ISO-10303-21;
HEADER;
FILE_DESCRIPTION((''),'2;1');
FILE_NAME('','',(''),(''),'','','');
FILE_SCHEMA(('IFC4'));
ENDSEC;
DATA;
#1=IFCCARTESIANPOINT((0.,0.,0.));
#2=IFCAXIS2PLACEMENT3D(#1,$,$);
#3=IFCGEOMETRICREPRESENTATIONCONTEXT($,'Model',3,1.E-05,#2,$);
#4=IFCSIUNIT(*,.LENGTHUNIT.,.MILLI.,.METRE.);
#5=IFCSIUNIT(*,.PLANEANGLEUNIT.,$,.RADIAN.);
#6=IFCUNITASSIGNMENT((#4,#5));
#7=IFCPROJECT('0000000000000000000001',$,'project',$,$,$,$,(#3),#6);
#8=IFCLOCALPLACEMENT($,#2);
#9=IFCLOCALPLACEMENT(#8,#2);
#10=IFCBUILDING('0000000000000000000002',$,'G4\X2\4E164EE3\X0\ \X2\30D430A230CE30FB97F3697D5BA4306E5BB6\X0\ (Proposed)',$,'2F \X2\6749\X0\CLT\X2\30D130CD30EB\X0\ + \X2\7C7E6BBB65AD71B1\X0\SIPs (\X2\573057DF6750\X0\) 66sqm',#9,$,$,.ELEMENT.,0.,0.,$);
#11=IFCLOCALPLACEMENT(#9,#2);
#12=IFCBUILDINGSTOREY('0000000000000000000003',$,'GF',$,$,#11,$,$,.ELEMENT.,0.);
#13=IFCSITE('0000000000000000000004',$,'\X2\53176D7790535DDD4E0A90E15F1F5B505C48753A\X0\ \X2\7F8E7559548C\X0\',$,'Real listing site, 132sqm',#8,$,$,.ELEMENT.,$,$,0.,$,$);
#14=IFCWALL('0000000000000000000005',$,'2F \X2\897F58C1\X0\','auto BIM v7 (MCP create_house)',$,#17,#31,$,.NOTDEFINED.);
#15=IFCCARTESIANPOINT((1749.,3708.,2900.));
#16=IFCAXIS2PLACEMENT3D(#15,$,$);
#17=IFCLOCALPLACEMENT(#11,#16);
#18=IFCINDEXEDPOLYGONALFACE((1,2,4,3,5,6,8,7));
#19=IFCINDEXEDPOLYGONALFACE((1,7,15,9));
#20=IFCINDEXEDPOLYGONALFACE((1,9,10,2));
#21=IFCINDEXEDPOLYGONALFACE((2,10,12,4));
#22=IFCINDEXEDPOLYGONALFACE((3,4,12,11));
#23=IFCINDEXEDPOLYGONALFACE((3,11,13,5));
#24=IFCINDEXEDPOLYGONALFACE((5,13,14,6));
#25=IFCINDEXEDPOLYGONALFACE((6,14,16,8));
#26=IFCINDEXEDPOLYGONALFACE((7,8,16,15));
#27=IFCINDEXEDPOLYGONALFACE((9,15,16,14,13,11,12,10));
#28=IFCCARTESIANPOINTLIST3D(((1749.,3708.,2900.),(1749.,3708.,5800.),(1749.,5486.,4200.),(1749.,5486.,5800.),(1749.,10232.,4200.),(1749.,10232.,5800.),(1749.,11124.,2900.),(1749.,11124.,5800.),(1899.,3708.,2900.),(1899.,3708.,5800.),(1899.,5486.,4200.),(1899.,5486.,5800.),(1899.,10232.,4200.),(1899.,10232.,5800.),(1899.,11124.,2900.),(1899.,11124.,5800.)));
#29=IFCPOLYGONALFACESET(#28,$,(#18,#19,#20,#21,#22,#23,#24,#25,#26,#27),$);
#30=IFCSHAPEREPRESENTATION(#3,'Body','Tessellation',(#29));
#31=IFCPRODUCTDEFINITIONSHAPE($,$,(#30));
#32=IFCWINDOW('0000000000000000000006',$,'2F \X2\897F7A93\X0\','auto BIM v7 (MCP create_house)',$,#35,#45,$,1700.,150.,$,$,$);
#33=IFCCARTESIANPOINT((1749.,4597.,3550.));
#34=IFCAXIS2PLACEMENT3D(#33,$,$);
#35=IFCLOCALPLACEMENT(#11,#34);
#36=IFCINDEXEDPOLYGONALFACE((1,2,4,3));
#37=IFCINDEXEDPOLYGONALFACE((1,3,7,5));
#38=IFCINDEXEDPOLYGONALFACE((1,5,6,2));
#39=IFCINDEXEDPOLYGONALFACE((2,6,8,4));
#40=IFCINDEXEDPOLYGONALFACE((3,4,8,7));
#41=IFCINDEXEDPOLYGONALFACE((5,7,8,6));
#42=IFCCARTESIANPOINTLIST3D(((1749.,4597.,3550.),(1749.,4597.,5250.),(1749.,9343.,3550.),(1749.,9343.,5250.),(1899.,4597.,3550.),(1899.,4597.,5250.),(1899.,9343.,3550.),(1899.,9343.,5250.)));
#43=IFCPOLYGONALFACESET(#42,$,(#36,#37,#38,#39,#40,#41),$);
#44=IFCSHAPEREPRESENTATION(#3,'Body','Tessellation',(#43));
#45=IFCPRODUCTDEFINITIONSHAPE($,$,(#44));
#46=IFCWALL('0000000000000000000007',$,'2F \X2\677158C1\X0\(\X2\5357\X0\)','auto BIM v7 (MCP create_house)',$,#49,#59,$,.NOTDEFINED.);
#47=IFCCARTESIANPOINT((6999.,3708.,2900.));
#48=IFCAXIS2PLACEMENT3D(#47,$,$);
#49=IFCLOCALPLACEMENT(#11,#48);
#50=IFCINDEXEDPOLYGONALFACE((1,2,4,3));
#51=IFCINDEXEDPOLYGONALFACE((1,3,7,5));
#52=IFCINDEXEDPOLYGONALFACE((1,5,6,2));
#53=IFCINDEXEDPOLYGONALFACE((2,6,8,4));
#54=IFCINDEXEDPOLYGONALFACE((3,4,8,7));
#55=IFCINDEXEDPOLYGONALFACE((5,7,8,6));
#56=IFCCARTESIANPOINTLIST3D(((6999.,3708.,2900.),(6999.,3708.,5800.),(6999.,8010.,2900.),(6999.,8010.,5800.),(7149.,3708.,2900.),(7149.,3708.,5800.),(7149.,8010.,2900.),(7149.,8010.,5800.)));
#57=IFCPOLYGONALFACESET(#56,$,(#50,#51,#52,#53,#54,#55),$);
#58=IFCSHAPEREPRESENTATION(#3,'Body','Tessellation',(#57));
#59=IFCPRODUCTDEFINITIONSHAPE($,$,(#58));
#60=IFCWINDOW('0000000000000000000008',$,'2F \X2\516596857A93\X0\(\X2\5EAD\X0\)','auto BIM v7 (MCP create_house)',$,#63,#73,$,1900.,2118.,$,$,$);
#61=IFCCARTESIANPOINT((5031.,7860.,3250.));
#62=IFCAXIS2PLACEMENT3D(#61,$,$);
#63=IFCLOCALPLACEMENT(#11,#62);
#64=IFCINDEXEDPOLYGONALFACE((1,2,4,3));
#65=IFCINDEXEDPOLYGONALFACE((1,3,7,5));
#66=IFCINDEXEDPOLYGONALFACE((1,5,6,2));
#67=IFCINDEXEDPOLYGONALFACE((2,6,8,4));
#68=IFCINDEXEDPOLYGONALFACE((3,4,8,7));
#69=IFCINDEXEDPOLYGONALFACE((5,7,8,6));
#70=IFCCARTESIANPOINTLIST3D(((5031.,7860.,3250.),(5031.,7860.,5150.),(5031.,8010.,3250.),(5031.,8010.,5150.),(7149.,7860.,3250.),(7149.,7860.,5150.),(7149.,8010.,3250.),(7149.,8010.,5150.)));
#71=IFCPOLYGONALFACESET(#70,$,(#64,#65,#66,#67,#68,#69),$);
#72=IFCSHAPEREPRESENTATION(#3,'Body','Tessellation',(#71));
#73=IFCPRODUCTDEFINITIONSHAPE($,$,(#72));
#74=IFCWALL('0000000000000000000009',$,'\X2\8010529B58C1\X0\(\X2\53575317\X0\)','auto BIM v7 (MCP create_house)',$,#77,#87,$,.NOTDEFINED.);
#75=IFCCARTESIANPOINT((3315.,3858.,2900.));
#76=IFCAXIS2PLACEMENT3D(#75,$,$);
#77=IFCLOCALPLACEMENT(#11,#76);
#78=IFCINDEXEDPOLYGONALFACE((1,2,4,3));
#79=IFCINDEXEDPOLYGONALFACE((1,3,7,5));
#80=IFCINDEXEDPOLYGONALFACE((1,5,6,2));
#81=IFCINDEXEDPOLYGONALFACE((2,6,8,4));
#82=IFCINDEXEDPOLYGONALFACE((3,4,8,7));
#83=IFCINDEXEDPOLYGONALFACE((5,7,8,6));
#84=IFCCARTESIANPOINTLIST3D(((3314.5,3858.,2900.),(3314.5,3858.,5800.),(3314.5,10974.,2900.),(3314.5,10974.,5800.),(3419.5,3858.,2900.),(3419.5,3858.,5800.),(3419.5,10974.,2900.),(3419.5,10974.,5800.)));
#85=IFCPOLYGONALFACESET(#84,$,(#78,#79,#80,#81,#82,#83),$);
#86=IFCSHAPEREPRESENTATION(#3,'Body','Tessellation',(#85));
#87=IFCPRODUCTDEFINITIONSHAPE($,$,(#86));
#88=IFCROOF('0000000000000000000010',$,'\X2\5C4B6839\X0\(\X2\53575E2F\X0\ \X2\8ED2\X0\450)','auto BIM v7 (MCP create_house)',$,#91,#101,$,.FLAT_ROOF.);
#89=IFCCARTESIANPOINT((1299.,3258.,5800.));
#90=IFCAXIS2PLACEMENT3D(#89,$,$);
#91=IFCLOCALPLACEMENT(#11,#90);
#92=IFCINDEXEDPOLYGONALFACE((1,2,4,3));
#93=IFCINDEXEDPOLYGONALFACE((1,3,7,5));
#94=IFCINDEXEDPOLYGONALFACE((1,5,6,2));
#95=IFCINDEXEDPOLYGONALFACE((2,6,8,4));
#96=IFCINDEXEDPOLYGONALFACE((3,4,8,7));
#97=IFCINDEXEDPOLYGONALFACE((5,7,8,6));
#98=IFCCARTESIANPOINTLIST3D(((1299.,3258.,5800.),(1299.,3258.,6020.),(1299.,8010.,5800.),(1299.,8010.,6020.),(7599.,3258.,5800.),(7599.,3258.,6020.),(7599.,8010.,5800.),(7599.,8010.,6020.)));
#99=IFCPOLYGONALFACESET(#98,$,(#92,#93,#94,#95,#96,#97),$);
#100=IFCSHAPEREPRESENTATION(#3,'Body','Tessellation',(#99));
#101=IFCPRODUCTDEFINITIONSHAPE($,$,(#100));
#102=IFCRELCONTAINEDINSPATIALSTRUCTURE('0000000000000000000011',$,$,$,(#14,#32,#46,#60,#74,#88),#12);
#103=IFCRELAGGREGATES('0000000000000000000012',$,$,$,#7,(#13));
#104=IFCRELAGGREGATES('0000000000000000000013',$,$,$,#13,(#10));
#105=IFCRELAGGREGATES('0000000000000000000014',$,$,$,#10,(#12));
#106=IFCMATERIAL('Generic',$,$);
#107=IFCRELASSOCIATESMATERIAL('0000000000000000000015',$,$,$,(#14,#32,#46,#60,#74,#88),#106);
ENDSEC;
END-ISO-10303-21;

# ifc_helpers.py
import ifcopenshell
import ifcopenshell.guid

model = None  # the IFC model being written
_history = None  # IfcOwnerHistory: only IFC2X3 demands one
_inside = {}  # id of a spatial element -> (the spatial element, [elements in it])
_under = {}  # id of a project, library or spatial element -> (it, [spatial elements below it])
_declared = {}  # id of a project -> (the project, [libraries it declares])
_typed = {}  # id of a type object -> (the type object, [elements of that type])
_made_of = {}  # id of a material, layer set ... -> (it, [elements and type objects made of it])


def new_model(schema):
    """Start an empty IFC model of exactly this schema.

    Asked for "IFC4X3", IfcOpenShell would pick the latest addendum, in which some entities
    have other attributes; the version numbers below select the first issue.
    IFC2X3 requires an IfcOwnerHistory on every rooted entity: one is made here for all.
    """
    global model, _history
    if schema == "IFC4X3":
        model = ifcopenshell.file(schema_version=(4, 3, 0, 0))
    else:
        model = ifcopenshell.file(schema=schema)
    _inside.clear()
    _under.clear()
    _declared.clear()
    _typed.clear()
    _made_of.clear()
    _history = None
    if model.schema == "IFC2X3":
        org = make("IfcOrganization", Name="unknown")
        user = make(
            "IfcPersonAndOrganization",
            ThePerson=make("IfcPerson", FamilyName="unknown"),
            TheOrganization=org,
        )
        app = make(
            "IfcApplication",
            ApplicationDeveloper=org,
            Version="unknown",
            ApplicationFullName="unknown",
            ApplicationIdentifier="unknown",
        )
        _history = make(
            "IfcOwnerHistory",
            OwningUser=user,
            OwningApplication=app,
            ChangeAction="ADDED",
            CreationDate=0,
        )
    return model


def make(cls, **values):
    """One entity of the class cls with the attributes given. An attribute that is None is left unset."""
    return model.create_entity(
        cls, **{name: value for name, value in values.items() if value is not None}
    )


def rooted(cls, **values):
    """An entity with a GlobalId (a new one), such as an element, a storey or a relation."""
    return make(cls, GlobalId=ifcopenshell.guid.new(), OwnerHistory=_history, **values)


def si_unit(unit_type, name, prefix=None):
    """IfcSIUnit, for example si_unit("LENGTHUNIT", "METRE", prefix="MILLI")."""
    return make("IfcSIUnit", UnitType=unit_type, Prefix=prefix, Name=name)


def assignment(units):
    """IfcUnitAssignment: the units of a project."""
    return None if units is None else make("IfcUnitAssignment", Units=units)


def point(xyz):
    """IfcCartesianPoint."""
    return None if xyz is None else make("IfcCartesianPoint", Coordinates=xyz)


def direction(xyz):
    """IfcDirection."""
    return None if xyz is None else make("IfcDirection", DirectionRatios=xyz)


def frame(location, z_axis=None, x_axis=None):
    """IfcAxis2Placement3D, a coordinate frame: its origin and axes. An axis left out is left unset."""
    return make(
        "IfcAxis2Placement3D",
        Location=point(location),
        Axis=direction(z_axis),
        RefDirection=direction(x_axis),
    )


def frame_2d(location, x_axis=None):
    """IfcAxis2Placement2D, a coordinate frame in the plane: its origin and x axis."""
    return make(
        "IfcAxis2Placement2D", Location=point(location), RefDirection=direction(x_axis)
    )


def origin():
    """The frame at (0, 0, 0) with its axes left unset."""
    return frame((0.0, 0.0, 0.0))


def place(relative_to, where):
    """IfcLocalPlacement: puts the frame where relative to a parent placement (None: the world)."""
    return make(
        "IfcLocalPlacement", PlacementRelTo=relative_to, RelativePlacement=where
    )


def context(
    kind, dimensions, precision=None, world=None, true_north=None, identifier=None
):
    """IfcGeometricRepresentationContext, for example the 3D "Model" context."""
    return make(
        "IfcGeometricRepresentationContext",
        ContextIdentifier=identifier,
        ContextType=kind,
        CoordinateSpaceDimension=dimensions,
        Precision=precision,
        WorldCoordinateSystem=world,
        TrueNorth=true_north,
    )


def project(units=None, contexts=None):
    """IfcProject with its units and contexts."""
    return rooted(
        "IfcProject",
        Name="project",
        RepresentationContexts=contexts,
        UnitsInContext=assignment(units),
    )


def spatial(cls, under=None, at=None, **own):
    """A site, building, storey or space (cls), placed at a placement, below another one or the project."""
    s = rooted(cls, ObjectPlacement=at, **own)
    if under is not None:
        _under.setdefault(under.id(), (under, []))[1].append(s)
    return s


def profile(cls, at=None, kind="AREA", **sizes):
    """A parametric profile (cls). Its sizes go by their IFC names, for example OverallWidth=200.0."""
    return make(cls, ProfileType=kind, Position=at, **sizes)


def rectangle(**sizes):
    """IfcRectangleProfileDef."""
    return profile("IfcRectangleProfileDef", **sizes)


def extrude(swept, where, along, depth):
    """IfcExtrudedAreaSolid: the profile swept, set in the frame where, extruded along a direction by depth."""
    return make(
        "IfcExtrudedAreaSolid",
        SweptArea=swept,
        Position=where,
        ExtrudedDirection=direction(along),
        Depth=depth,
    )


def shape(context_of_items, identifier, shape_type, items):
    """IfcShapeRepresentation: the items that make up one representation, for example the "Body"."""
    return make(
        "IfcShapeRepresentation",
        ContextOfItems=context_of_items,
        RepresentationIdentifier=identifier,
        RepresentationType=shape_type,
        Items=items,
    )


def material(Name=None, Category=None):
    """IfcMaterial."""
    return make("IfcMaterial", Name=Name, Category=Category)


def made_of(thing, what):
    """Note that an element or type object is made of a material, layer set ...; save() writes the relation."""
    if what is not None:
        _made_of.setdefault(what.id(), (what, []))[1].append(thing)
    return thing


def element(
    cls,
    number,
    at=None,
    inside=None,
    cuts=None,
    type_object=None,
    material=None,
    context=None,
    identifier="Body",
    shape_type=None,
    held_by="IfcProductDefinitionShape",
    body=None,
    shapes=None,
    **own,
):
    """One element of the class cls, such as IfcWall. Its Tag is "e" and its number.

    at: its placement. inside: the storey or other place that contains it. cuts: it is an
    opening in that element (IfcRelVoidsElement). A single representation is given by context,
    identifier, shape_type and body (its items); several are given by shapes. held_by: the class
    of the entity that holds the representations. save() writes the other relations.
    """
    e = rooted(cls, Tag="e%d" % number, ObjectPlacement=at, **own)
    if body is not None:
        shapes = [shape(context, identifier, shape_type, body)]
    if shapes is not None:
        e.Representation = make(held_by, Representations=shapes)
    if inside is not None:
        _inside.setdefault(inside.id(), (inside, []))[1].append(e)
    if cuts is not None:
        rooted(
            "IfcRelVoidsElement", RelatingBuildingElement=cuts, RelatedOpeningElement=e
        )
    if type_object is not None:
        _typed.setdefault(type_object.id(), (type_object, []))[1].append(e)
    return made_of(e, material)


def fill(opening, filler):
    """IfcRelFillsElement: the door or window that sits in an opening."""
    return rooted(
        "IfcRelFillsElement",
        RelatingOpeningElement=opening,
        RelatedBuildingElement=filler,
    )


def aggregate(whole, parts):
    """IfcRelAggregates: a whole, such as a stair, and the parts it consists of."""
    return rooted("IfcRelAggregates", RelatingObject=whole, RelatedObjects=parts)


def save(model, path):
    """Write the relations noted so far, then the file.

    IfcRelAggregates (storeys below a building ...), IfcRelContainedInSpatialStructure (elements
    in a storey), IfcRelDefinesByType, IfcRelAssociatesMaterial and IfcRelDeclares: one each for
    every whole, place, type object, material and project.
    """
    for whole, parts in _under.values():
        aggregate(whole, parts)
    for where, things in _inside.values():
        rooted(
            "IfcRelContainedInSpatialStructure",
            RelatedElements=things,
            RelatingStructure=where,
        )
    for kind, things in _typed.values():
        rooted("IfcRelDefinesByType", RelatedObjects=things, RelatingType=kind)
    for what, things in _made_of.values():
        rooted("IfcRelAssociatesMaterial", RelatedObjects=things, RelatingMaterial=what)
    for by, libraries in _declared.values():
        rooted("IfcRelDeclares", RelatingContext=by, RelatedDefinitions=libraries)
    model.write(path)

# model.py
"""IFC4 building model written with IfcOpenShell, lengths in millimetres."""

from ifc_helpers import new_model, si_unit, frame, frame_2d, origin, place, context, project, spatial, rectangle, extrude, material, element, fill, save


model = new_model("IFC4")

# Units and contexts
model_context = context("Model", 3, precision=1e-05, world=origin())
ifc_project = project(units=[si_unit("LENGTHUNIT", "METRE", prefix="MILLI"), si_unit("PLANEANGLEUNIT", "RADIAN")], contexts=[model_context])

# Site, building, storey
site_placement = place(None, origin())
site = spatial("IfcSite", under=ifc_project, at=site_placement, Name="北海道川上郡弟子屈町 美留和", ObjectType="Real listing site, 132sqm", CompositionType="ELEMENT", RefElevation=0.0)
building_placement = place(site_placement, origin())
building = spatial("IfcBuilding", under=site, at=building_placement, Name="G4世代 ピアノ・音楽室の家 (Proposed)", ObjectType="2F 杉CLTパネル + 籾殻断熱SIPs (地域材) 66sqm", CompositionType="ELEMENT", ElevationOfRefHeight=0.0, ElevationOfTerrain=0.0)
storey_placement = place(building_placement, origin())
storey = spatial("IfcBuildingStorey", under=building, at=storey_placement, Name="GF", CompositionType="ELEMENT", Elevation=0.0)

# Shared definitions
ifc_material = material(Name="Generic")

# Walls, openings, windows
wall_1_placement = place(storey_placement, frame((1749.0, 3708.0, 2900.0)))
wall_1 = element("IfcWall", 1, at=wall_1_placement, inside=storey, material=ifc_material, Name="2F 西壁", Description="auto BIM v7 (MCP create_house)", PredefinedType="NOTDEFINED", context=model_context, shape_type="SweptSolid", body=[
    extrude(rectangle(XDim=150.0, YDim=7416.0, at=frame_2d((75.0, 3708.0))), frame((1749.0, 3708.0, 2900.0)), (0.0, 0.0, 1.0), 2900.0),
])
opening_1_placement = place(storey_placement, frame((1749.0, 4597.0, 3550.0)))
opening_1 = element("IfcOpeningElement", 2, at=opening_1_placement, cuts=wall_1, PredefinedType="NOTDEFINED", context=model_context, shape_type="SweptSolid", body=[
    extrude(rectangle(XDim=150.0, YDim=4746.0, at=frame_2d((75.0, 2373.0))), frame((1749.0, 4597.0, 3550.0)), (0.0, 0.0, 1.0), 1700.0),
])
window_1_placement = place(storey_placement, frame((1749.0, 4597.0, 3550.0)))
window_1 = element("IfcWindow", 3, at=window_1_placement, inside=storey, material=ifc_material, Name="2F 西窓", Description="auto BIM v7 (MCP create_house)", OverallHeight=1700.0, OverallWidth=150.0, context=model_context, shape_type="SweptSolid", body=[
    extrude(rectangle(XDim=150.0, YDim=4746.0, at=frame_2d((75.0, 2373.0))), frame((1749.0, 4597.0, 3550.0)), (0.0, 0.0, 1.0), 1700.0),
])
fill(opening_1, window_1)
wall_2_placement = place(storey_placement, frame((6999.0, 3708.0, 2900.0)))
wall_2 = element("IfcWall", 4, at=wall_2_placement, inside=storey, material=ifc_material, Name="2F 東壁(南)", Description="auto BIM v7 (MCP create_house)", PredefinedType="NOTDEFINED", context=model_context, shape_type="SweptSolid", body=[
    extrude(rectangle(XDim=150.0, YDim=4302.0, at=frame_2d((75.0, 2151.0))), frame((6999.0, 3708.0, 2900.0)), (0.0, 0.0, 1.0), 2900.0),
])
opening_2_placement = place(storey_placement, frame((5031.0, 7860.0, 3250.0)))
opening_2 = element("IfcOpeningElement", 5, at=opening_2_placement, cuts=wall_2, PredefinedType="NOTDEFINED", context=model_context, shape_type="SweptSolid", body=[
    extrude(rectangle(XDim=2118.0, YDim=150.0, at=frame_2d((1059.0, 75.0))), frame((5031.0, 7860.0, 3250.0)), (0.0, 0.0, 1.0), 1900.0),
])
window_2_placement = place(storey_placement, frame((5031.0, 7860.0, 3250.0)))
window_2 = element("IfcWindow", 6, at=window_2_placement, inside=storey, material=ifc_material, Name="2F 入隅窓(庭)", Description="auto BIM v7 (MCP create_house)", OverallHeight=1900.0, OverallWidth=2118.0, context=model_context, shape_type="SweptSolid", body=[
    extrude(rectangle(XDim=2118.0, YDim=150.0, at=frame_2d((1059.0, 75.0))), frame((5031.0, 7860.0, 3250.0)), (0.0, 0.0, 1.0), 1900.0),
])
fill(opening_2, window_2)

# Wall
wall_3_placement = place(storey_placement, frame((3315.0, 3858.0, 2900.0)))
element("IfcWall", 7, at=wall_3_placement, inside=storey, material=ifc_material, Name="耐力壁(南北)", Description="auto BIM v7 (MCP create_house)", PredefinedType="NOTDEFINED", context=model_context, shape_type="SweptSolid", body=[
    extrude(rectangle(XDim=105.0, YDim=7116.0, at=frame_2d((52.0, 3558.0))), frame((3315.0, 3858.0, 2900.0)), (0.0, 0.0, 1.0), 2900.0),
])

# Roof
for number, where, name in (
    (8, (1299.0, 3258.0, 5800.0), "屋根(南帯 軒450)"),
):
    element("IfcRoof", number, at=place(storey_placement, frame(where)), inside=storey, material=ifc_material, Name=name, Description="auto BIM v7 (MCP create_house)", PredefinedType="FLAT_ROOF", context=model_context, shape_type="SweptSolid", body=[
        extrude(rectangle(XDim=6300.0, YDim=4752.0, at=frame_2d((3150.0, 2376.0))), frame((1299.0, 3258.0, 5800.0)), (0.0, 0.0, 1.0), 220.0),
    ])

save(model, "model.ifc")
